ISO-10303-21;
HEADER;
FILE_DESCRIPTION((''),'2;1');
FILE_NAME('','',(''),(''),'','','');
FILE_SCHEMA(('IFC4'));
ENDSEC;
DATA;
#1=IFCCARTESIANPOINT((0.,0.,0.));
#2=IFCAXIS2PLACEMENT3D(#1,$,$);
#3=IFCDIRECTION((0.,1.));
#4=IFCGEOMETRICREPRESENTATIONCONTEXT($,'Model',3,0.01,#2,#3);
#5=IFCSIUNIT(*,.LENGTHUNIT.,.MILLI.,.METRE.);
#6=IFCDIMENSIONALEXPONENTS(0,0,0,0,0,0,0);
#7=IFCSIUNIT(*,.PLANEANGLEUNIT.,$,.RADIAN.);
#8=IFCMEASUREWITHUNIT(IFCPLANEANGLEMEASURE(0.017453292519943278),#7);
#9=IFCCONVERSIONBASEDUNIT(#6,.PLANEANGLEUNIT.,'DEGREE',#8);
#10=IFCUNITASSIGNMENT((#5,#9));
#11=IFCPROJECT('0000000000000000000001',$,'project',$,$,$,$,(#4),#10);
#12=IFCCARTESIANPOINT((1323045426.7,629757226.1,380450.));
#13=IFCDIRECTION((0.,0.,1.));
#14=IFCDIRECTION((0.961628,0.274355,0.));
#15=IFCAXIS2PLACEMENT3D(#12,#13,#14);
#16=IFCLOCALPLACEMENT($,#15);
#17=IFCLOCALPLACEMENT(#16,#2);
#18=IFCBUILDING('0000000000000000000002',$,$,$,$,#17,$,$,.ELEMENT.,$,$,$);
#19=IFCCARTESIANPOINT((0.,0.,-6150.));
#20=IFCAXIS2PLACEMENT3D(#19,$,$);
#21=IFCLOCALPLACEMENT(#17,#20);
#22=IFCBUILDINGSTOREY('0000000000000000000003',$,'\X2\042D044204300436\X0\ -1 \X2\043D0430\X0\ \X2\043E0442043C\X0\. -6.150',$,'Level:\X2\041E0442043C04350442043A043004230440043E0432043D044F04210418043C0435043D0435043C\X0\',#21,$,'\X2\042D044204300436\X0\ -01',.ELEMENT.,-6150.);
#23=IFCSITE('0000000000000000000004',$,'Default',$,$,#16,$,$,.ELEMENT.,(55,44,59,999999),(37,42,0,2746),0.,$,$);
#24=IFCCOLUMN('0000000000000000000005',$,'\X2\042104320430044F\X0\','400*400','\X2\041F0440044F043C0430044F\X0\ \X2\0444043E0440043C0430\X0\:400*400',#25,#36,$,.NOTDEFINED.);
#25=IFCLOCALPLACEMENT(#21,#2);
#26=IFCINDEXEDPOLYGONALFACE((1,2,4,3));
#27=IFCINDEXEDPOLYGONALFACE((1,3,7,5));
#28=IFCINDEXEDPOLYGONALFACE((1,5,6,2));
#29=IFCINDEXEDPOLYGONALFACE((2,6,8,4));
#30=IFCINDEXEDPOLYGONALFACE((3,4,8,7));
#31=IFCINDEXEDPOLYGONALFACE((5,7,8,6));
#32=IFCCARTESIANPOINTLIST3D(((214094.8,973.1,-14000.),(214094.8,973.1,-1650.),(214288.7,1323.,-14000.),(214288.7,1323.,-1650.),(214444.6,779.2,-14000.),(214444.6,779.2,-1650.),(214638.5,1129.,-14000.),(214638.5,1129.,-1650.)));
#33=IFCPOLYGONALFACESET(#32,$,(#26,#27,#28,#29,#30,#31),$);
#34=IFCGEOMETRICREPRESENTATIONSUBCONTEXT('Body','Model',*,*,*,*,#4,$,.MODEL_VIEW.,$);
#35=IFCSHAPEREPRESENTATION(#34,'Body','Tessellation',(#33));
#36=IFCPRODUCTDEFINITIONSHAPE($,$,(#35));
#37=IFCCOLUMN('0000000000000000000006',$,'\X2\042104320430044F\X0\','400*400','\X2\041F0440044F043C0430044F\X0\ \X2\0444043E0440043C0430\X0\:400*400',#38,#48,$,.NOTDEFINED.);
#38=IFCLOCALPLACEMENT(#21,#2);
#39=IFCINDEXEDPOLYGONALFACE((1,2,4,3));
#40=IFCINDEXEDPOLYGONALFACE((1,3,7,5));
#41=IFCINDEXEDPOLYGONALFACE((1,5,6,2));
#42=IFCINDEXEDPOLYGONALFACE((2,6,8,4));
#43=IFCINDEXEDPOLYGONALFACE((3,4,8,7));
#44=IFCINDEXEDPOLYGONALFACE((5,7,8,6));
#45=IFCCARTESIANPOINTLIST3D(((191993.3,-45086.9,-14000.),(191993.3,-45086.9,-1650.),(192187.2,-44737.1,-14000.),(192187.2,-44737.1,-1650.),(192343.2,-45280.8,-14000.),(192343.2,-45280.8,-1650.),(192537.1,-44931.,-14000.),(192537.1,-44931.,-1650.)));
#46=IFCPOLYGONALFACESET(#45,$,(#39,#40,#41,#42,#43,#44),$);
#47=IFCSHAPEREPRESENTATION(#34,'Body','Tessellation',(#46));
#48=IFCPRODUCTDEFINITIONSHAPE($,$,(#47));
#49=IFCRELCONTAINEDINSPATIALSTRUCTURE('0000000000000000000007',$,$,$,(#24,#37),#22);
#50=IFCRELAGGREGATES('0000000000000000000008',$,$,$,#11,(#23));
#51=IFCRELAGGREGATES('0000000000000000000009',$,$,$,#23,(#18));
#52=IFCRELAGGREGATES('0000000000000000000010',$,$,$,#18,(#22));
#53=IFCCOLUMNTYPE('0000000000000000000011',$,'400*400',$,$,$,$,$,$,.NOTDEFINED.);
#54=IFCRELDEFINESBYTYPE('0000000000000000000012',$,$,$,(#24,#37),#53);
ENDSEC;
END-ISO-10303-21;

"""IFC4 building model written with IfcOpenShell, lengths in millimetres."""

from ifc_helpers import new_model, entity, si_unit, converted_unit, direction, frame, origin, place, context, subcontext, project, spatial, indexed_curve, outline, extrude, type_object, element, save


model = new_model("IFC4")

# Units and contexts
model_context = context("Model", 3, precision=0.01, world=origin(), true_north=direction((0.0, 1.0)))
body_context = subcontext(model_context, "Body", "Model", "MODEL_VIEW")
ifc_project = project(units=[si_unit("LENGTHUNIT", "METRE", prefix="MILLI"), converted_unit("PLANEANGLEUNIT", "DEGREE", entity("IfcPlaneAngleMeasure", 0.017453292519943278), si_unit("PLANEANGLEUNIT", "RADIAN"), dimensions=[0, 0, 0, 0, 0, 0, 0])], contexts=[model_context])

# Site, building, storey
site_placement = place(None, frame((1323045426.7, 629757226.1, 380450.0), z_axis=(0.0, 0.0, 1.0), x_axis=(0.961628, 0.274355, 0.0)))
site = spatial("IfcSite", under=ifc_project, at=site_placement, Name="Default", CompositionType="ELEMENT", RefLatitude=(55, 44, 59, 999999), RefLongitude=(37, 42, 0, 2746), RefElevation=0.0)
building_placement = place(site_placement, origin())
building = spatial("IfcBuilding", under=site, at=building_placement, CompositionType="ELEMENT")
storey_placement = place(building_placement, frame((0.0, 0.0, -6150.0)))
storey = spatial("IfcBuildingStorey", under=building, at=storey_placement, Name="Этаж -1 на отм. -6.150", ObjectType="Level:ОтметкаУровняСИменем", LongName="Этаж -01", CompositionType="ELEMENT", Elevation=-6150.0)

# Columns
column_type = type_object("IfcColumnType", Name="400*400", PredefinedType="NOTDEFINED")
column_1_placement = place(storey_placement, origin())
element("IfcColumn", 1, at=column_1_placement, inside=storey, type_object=column_type, Name="Свая", Description="400*400", ObjectType="Прямая форма:400*400", PredefinedType="NOTDEFINED", context=body_context, shape_type="SweptSolid", body=[
    extrude(outline(indexed_curve([(-200.0, -200.0), (200.0, -200.0), (200.0, 200.0), (-200.0, 200.0), (-200.0, -200.0)], self_intersect=False)), frame((214366.6, 1051.1, -14000.0), z_axis=(0.0, 0.0, 1.0), x_axis=(0.48481, 0.87462, 0.0)), (0.0, 0.0, 1.0), 12350.0),
])
column_2_placement = place(storey_placement, origin())
element("IfcColumn", 2, at=column_2_placement, inside=storey, type_object=column_type, Name="Свая", Description="400*400", ObjectType="Прямая форма:400*400", PredefinedType="NOTDEFINED", context=body_context, shape_type="SweptSolid", body=[
    extrude(outline(indexed_curve([(-200.0, -200.0), (200.0, -200.0), (200.0, 200.0), (-200.0, 200.0), (-200.0, -200.0)], self_intersect=False)), frame((192265.2, -45008.9, -14000.0), z_axis=(0.0, 0.0, 1.0), x_axis=(0.48481, 0.87462, 0.0)), (0.0, 0.0, 1.0), 12350.0),
])

save(model, "model.ifc")
